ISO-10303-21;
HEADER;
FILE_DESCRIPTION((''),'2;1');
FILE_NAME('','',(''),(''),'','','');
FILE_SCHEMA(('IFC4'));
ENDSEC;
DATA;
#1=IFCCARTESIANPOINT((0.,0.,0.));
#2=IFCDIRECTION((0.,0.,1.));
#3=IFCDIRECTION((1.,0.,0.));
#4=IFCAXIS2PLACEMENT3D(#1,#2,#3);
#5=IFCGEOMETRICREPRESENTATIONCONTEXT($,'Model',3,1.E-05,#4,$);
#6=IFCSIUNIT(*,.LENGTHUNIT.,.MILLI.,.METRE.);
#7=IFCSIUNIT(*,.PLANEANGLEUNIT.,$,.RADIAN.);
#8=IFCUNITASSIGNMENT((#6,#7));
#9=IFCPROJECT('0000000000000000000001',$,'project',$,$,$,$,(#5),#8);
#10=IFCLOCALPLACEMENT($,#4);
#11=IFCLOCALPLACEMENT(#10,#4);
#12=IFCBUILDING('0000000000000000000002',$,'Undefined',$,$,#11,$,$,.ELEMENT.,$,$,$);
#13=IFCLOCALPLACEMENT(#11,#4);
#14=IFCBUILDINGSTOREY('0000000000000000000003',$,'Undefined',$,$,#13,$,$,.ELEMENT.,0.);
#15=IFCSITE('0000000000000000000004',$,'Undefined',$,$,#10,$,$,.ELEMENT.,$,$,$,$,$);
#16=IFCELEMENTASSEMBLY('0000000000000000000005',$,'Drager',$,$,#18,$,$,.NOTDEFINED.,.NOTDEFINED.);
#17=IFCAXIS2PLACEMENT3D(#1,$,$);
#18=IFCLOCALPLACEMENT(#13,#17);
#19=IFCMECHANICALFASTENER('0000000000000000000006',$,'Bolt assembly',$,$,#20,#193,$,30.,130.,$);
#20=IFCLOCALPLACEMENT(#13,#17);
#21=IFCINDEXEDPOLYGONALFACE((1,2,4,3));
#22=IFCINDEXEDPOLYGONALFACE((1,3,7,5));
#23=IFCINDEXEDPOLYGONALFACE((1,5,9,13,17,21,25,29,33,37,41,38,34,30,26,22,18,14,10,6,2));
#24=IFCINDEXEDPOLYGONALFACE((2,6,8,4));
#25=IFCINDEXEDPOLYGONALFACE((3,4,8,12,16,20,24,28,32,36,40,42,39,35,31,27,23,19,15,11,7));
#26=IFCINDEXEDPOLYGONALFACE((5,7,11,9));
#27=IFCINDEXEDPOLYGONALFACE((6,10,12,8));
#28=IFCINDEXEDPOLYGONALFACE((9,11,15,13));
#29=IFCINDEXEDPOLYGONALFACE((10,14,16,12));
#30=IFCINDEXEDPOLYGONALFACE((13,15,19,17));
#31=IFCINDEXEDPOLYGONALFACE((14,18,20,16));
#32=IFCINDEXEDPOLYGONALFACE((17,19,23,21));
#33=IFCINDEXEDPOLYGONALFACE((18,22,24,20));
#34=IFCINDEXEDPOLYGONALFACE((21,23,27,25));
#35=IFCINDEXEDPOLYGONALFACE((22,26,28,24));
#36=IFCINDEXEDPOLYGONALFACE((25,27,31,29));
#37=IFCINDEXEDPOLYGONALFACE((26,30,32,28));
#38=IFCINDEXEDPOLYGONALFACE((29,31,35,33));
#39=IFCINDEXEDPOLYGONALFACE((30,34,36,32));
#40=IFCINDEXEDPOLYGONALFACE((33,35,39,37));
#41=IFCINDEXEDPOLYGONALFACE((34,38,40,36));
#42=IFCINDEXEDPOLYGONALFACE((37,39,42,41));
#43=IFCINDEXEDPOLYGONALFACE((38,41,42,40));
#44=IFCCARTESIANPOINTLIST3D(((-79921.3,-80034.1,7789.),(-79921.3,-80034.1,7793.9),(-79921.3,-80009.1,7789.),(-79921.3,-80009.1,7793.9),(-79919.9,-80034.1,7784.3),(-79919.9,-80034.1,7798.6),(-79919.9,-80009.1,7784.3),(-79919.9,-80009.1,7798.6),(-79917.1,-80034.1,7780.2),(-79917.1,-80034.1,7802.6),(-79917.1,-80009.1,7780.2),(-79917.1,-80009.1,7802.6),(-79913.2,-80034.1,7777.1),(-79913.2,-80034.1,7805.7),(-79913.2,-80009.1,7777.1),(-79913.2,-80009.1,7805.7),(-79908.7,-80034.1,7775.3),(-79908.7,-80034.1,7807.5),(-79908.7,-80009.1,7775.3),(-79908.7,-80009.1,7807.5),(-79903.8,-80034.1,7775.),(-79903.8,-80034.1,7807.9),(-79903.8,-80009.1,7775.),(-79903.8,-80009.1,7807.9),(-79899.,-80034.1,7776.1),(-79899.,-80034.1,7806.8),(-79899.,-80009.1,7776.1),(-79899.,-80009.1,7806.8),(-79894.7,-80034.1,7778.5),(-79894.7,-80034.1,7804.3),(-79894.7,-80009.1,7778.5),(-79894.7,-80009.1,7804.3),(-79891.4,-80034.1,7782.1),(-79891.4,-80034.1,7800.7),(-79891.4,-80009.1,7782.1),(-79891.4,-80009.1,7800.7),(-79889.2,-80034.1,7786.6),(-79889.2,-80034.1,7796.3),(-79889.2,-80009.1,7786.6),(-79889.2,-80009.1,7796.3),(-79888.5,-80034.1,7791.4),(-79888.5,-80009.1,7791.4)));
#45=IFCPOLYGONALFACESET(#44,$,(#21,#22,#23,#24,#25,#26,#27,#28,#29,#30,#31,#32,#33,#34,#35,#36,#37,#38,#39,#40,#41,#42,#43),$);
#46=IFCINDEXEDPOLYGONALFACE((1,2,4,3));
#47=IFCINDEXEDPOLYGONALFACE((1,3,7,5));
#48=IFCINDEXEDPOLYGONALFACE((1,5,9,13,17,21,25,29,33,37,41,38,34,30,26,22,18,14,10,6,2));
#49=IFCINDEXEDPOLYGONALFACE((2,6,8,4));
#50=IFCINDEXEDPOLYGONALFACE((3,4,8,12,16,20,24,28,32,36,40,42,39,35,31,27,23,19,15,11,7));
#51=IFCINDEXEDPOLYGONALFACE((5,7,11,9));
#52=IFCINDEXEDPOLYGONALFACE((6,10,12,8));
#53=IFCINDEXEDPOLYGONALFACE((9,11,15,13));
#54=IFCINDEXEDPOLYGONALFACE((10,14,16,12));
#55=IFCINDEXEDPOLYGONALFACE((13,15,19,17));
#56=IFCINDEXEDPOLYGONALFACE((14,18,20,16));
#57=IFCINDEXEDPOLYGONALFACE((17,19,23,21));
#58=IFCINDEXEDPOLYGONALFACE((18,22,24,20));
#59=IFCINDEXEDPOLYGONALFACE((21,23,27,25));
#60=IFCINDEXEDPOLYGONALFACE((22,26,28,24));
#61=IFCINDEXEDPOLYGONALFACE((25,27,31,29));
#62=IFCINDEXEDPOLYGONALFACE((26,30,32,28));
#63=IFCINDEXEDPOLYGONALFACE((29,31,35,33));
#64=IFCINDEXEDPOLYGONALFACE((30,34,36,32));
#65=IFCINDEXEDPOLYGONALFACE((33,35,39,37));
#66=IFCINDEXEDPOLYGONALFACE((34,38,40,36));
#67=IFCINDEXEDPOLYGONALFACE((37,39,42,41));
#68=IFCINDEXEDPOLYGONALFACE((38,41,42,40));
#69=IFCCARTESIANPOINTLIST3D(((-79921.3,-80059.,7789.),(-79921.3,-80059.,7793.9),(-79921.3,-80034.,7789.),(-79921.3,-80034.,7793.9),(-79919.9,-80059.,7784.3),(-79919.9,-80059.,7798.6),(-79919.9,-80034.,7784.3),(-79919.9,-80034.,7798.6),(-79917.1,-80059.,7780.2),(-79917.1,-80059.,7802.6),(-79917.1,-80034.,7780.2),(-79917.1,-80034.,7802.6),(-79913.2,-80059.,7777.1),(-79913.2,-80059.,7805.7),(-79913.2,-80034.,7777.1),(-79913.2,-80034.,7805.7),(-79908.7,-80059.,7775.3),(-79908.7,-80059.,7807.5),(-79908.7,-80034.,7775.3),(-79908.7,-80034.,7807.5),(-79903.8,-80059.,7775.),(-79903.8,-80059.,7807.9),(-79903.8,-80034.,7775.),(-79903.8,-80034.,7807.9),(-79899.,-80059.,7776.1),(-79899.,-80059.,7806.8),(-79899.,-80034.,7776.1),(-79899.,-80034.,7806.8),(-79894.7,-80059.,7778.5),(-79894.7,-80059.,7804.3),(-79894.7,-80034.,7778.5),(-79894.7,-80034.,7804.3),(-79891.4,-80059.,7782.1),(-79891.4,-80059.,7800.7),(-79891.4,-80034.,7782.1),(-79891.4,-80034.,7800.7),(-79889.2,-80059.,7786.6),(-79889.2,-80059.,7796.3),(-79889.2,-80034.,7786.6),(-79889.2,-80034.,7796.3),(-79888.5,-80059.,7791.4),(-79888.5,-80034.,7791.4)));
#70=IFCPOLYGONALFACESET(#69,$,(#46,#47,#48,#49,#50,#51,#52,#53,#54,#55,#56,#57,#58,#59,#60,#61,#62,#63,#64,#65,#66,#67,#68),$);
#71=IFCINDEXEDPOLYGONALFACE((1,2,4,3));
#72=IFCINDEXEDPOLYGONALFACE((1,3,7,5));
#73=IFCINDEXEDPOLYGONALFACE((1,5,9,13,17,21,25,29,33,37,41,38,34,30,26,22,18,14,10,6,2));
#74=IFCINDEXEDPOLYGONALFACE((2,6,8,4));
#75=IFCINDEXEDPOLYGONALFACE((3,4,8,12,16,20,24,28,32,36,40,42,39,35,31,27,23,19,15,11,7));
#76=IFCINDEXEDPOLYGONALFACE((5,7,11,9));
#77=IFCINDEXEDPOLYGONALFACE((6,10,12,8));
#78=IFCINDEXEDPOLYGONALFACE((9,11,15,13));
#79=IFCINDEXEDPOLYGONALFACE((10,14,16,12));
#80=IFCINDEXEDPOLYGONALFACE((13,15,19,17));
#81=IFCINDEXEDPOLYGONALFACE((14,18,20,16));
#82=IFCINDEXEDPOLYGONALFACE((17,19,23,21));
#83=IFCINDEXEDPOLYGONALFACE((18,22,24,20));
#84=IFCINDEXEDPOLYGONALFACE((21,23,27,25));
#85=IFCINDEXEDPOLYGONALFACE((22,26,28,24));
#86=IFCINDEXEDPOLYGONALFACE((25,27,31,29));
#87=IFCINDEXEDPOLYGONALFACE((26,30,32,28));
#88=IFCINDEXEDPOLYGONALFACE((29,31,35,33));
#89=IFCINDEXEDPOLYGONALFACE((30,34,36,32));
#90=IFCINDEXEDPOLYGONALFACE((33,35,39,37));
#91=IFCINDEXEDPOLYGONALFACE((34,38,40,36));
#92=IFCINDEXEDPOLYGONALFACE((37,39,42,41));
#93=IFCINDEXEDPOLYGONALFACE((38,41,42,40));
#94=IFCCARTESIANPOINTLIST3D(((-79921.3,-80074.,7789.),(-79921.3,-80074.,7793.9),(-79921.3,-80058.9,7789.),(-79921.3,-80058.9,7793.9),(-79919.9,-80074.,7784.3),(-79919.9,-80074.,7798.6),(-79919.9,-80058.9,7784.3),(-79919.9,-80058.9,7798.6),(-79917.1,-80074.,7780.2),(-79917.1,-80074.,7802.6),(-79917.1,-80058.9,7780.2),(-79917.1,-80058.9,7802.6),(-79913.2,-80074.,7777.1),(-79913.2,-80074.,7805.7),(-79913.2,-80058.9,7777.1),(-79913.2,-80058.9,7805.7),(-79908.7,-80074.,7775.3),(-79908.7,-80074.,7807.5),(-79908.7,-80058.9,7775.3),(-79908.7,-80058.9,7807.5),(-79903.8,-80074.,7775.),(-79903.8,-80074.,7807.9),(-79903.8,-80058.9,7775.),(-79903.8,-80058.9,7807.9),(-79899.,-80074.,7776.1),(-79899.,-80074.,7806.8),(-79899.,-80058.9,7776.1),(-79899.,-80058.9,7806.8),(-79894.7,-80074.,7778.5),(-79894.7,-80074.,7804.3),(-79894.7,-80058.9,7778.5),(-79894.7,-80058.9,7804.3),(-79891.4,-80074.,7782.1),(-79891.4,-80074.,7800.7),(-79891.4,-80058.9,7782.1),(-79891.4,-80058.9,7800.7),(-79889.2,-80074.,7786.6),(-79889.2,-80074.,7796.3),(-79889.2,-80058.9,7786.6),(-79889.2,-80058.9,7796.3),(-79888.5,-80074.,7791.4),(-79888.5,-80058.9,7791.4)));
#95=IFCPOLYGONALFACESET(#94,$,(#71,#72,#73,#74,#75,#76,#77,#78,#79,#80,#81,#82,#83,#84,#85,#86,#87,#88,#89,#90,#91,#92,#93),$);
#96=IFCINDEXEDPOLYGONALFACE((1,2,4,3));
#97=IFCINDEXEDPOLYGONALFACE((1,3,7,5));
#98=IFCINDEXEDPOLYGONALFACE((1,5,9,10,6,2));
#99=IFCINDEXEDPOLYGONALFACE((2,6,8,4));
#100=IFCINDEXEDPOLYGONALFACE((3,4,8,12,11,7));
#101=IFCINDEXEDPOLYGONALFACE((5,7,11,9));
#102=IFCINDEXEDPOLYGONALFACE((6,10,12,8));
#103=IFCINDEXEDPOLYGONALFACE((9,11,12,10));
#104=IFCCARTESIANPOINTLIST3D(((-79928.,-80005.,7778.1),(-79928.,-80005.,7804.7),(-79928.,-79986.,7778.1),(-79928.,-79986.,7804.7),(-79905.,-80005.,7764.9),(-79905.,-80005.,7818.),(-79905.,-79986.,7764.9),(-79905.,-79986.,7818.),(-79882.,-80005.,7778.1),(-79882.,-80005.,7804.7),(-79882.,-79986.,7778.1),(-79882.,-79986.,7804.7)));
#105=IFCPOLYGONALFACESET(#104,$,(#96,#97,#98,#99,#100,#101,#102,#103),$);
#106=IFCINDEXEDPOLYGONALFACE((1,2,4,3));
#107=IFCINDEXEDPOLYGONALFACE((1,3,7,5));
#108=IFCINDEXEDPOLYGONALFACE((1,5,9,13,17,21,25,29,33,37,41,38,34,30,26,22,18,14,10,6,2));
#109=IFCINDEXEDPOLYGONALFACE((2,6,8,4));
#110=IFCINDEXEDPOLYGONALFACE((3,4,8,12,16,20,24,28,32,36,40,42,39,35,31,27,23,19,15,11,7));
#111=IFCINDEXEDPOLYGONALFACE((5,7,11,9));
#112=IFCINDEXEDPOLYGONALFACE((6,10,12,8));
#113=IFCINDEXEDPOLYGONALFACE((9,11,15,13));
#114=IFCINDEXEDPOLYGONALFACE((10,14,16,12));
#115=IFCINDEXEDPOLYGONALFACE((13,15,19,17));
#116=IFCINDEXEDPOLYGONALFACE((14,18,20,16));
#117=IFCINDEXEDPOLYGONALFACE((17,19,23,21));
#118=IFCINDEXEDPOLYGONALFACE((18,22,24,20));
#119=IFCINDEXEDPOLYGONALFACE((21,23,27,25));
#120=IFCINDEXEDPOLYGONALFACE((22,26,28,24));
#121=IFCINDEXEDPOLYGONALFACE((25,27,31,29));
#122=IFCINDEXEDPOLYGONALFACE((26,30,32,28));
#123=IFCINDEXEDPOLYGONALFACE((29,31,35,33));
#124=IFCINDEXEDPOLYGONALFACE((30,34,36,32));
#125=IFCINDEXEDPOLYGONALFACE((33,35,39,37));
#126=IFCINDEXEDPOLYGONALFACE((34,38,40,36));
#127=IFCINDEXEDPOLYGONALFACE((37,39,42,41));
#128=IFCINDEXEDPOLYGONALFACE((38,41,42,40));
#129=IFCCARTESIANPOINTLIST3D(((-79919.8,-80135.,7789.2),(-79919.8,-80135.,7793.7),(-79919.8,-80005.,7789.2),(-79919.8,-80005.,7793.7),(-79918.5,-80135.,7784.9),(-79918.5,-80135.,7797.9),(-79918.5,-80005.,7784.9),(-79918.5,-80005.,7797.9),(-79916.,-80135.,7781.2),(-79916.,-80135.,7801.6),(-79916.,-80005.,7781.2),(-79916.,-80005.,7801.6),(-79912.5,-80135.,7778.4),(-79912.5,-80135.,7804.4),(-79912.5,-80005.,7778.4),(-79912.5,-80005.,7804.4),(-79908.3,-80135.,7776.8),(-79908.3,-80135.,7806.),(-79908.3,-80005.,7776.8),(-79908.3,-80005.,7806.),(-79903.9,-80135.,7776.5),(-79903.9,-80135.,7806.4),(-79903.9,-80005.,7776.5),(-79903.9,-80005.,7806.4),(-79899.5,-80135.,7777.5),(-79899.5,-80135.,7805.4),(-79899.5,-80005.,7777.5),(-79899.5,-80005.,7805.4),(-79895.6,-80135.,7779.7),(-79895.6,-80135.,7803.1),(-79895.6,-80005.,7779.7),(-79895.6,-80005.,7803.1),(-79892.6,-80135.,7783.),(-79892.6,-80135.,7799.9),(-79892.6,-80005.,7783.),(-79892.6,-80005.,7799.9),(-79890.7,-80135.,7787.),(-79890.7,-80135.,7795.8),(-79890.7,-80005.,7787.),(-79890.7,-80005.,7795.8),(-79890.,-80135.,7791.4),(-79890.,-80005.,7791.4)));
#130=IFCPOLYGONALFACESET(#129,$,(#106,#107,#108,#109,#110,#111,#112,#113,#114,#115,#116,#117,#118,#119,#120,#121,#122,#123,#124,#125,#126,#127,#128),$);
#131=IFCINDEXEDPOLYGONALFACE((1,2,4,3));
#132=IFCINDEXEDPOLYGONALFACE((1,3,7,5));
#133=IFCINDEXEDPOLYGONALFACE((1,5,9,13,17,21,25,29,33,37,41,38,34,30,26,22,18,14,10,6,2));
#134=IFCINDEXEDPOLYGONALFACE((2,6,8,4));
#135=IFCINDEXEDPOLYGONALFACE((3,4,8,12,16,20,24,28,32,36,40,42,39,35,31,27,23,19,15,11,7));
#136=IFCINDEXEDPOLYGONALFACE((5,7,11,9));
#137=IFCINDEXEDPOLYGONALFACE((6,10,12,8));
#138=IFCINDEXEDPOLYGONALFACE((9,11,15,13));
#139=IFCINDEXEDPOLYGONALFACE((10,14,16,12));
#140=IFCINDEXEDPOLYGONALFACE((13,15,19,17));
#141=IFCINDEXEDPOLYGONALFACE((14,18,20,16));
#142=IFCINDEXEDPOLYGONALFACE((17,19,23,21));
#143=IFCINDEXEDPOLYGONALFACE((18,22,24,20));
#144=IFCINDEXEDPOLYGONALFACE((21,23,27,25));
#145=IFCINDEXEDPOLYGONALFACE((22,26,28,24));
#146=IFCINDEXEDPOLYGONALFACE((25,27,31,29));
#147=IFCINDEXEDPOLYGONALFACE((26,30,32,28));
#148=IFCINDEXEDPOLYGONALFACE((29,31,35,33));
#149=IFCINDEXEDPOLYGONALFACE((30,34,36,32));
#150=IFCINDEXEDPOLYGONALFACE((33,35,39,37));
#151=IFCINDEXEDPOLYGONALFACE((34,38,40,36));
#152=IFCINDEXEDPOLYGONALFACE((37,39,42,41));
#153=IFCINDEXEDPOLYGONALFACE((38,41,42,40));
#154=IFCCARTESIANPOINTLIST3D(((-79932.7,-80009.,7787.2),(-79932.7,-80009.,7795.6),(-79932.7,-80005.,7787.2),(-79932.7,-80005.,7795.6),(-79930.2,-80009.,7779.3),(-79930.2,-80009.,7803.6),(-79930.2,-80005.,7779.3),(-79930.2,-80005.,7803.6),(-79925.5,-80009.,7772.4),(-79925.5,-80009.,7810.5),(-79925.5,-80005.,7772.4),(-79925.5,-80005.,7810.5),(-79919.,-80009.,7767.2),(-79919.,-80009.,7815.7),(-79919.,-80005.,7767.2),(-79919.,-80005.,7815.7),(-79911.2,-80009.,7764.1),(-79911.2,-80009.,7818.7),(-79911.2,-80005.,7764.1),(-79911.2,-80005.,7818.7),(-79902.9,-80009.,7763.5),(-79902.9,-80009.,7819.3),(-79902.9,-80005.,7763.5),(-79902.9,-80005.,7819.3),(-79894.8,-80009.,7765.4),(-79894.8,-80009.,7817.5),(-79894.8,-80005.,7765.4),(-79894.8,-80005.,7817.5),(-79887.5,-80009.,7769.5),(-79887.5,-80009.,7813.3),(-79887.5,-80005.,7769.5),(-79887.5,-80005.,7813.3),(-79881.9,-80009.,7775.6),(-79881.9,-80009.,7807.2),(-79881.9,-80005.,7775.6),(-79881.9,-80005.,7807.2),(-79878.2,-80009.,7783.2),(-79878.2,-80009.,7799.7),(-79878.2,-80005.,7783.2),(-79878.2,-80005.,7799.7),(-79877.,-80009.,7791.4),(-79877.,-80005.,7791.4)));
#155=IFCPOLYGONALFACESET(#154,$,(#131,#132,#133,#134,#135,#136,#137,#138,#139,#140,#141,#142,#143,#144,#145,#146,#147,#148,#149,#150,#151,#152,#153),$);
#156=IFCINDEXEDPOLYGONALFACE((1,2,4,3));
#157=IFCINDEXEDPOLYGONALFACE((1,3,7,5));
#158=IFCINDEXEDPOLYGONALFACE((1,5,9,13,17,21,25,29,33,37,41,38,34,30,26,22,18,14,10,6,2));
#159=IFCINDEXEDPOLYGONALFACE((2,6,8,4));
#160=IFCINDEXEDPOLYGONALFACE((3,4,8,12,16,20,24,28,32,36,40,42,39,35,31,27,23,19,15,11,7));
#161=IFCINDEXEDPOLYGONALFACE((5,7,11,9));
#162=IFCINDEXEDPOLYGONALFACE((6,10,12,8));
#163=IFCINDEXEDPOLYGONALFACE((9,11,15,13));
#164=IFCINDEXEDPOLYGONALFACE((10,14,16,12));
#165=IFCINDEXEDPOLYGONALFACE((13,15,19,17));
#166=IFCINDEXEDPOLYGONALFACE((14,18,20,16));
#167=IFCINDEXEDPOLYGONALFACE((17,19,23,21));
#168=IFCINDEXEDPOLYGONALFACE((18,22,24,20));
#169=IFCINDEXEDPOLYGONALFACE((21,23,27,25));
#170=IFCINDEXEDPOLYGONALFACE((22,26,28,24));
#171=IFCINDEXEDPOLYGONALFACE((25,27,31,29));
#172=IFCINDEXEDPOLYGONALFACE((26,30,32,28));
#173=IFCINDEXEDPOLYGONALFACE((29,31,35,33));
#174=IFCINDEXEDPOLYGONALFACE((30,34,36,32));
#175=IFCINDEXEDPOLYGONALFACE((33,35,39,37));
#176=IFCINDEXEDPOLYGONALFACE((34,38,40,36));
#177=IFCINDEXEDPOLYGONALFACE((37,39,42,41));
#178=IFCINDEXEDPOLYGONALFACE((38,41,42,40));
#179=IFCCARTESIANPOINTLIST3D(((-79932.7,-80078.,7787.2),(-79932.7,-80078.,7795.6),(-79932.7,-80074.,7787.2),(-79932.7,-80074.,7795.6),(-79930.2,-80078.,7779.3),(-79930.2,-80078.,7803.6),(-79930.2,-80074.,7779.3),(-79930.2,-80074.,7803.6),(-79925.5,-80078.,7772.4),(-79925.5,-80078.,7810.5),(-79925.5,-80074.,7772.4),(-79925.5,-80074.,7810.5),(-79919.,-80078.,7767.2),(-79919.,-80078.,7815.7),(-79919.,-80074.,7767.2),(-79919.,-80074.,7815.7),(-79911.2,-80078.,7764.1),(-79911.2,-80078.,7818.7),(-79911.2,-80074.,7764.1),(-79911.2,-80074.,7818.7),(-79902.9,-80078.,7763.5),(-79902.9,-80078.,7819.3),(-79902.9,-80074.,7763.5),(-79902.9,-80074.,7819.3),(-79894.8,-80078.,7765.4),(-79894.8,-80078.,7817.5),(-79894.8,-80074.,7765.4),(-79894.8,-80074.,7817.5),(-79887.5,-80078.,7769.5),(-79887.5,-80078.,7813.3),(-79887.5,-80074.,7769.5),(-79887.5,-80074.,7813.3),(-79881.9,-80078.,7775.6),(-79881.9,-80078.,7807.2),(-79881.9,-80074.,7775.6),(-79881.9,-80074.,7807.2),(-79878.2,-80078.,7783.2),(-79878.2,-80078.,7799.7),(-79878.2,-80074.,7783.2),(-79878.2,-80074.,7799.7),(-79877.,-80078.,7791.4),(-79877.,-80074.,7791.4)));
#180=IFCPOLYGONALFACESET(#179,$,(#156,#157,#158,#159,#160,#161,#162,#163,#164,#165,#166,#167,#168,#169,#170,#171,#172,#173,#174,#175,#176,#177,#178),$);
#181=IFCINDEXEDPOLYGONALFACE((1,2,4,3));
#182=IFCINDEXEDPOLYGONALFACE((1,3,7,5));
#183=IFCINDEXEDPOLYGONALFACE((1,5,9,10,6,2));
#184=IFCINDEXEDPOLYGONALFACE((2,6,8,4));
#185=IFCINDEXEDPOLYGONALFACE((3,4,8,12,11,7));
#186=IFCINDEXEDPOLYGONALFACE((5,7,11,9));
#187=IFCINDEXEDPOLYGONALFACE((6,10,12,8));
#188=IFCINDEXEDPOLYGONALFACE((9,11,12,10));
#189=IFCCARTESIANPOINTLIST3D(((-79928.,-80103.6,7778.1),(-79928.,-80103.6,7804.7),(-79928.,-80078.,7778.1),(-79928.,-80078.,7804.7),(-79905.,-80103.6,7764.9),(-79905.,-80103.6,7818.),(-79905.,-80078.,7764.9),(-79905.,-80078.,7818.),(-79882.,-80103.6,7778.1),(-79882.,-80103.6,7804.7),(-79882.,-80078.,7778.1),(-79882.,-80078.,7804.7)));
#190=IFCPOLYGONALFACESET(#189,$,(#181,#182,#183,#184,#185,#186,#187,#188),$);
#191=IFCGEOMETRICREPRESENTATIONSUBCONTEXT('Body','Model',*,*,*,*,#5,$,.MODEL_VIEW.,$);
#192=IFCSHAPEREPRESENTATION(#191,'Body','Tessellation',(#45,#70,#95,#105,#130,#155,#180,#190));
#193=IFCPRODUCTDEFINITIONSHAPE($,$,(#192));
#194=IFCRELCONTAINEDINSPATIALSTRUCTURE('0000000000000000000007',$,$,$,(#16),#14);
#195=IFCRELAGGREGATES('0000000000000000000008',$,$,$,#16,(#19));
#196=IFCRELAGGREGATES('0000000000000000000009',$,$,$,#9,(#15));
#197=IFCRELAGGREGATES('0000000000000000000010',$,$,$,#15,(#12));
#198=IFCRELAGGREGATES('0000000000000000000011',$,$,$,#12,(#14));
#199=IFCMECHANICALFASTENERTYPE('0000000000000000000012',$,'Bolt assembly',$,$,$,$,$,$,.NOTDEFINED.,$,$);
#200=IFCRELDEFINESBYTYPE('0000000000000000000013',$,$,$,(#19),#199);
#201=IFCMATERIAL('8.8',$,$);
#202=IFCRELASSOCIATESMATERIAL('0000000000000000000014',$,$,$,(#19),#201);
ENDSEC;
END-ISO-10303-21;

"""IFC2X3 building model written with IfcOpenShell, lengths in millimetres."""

from ifc_helpers import new_model, si_unit, frame, origin_with_axes, origin_2d_with_axis, place, context, subcontext, project, spatial, polyline, circle, outline, extrude, source, transform, mapped, material, type_object, element, aggregate, save


model = new_model("IFC2X3")

# Units and contexts
model_context = context("Model", 3, precision=1e-05, world=origin_with_axes())
body_context = subcontext(model_context, "Body", "Model", "MODEL_VIEW")
ifc_project = project(units=[si_unit("LENGTHUNIT", "METRE", prefix="MILLI"), si_unit("PLANEANGLEUNIT", "RADIAN")], contexts=[model_context])

# Site, building, storey
site_placement = place(None, origin_with_axes())
site = spatial("IfcSite", under=ifc_project, at=site_placement, Name="Undefined", CompositionType="ELEMENT")
building_placement = place(site_placement, origin_with_axes())
building = spatial("IfcBuilding", under=site, at=building_placement, Name="Undefined", CompositionType="ELEMENT")
storey_placement = place(building_placement, origin_with_axes())
storey = spatial("IfcBuildingStorey", under=building, at=storey_placement, Name="Undefined", CompositionType="ELEMENT", Elevation=0.0)

# Shared definitions
ifc_material_1 = material(Name="8.8")
mechanical_fastener_type = type_object("IfcMechanicalFastenerType", Name="Bolt assembly")

# Element assembly, mechanical fastener
assembly_1_placement = place(storey_placement, origin_with_axes())
assembly_1 = element("IfcElementAssembly", 1, at=assembly_1_placement, inside=storey, Name="Drager", AssemblyPlace="NOTDEFINED", PredefinedType="NOTDEFINED")
shared_shape_1 = source(origin_with_axes(), body_context, "Body", "SweptSolid", [
    extrude(circle(Radius=16.5, at=origin_2d_with_axis()), frame((0.0, -57.4, 0.0), z_axis=(0.0, 1.0, 0.0), x_axis=(1.0, 0.0, 0.0)), (0.0, 0.0, 1.0), 25.0),
    extrude(circle(Radius=16.5, at=origin_2d_with_axis()), frame((0.0, -32.5, 0.0), z_axis=(0.0, 1.0, 0.0), x_axis=(1.0, 0.0, 0.0)), (0.0, 0.0, 1.0), 25.0),
    extrude(circle(Radius=16.5, at=origin_2d_with_axis()), frame((0.0, -7.6, 0.0), z_axis=(0.0, 1.0, 0.0), x_axis=(1.0, 0.0, 0.0)), (0.0, 0.0, 1.0), 15.1),
    extrude(outline(polyline([(23.0, -13.3), (23.0, 13.3), (0.0, 26.6), (-23.0, 13.3), (-23.0, -13.3), (0.0, -26.6), (23.0, -13.3)])), frame((0.0, -80.5, 0.0), z_axis=(0.0, 1.0, 0.0), x_axis=(1.0, 0.0, 0.0)), (0.0, 0.0, 1.0), 19.0),
    extrude(circle(Radius=15.0, at=origin_2d_with_axis()), frame((0.0, -61.5, 0.0), z_axis=(0.0, 1.0, 0.0), x_axis=(1.0, 0.0, 0.0)), (0.0, 0.0, 1.0), 130.0),
    extrude(circle(Radius=28.0, at=origin_2d_with_axis()), frame((0.0, -61.5, 0.0), z_axis=(0.0, 1.0, 0.0), x_axis=(1.0, 0.0, 0.0)), (0.0, 0.0, 1.0), 4.0),
    extrude(circle(Radius=28.0, at=origin_2d_with_axis()), frame((0.0, 7.5, 0.0), z_axis=(0.0, 1.0, 0.0), x_axis=(1.0, 0.0, 0.0)), (0.0, 0.0, 1.0), 4.0),
    extrude(outline(polyline([(23.0, -13.3), (23.0, 13.3), (0.0, 26.6), (-23.0, 13.3), (-23.0, -13.3), (0.0, -26.6), (23.0, -13.3)])), frame((0.0, 11.5, 0.0), z_axis=(0.0, 1.0, 0.0), x_axis=(1.0, 0.0, 0.0)), (0.0, 0.0, 1.0), 25.6),
])
mechanical_fastener_1_placement = place(assembly_1_placement, frame((-79905.0, -80066.5, 7791.4), z_axis=(0.0, 0.0, -1.0), x_axis=(1.0, 0.0, 0.0)))
mechanical_fastener_1 = element("IfcMechanicalFastener", 2, at=mechanical_fastener_1_placement, type_object=mechanical_fastener_type, material=ifc_material_1, Name="Bolt assembly", NominalDiameter=30.0, NominalLength=130.0, context=body_context, shape_type="MappedRepresentation", body=[
    mapped(shared_shape_1, transform((0.0, 0.0, 0.0))),
])
aggregate(assembly_1, [mechanical_fastener_1])

save(model, "model.ifc")
